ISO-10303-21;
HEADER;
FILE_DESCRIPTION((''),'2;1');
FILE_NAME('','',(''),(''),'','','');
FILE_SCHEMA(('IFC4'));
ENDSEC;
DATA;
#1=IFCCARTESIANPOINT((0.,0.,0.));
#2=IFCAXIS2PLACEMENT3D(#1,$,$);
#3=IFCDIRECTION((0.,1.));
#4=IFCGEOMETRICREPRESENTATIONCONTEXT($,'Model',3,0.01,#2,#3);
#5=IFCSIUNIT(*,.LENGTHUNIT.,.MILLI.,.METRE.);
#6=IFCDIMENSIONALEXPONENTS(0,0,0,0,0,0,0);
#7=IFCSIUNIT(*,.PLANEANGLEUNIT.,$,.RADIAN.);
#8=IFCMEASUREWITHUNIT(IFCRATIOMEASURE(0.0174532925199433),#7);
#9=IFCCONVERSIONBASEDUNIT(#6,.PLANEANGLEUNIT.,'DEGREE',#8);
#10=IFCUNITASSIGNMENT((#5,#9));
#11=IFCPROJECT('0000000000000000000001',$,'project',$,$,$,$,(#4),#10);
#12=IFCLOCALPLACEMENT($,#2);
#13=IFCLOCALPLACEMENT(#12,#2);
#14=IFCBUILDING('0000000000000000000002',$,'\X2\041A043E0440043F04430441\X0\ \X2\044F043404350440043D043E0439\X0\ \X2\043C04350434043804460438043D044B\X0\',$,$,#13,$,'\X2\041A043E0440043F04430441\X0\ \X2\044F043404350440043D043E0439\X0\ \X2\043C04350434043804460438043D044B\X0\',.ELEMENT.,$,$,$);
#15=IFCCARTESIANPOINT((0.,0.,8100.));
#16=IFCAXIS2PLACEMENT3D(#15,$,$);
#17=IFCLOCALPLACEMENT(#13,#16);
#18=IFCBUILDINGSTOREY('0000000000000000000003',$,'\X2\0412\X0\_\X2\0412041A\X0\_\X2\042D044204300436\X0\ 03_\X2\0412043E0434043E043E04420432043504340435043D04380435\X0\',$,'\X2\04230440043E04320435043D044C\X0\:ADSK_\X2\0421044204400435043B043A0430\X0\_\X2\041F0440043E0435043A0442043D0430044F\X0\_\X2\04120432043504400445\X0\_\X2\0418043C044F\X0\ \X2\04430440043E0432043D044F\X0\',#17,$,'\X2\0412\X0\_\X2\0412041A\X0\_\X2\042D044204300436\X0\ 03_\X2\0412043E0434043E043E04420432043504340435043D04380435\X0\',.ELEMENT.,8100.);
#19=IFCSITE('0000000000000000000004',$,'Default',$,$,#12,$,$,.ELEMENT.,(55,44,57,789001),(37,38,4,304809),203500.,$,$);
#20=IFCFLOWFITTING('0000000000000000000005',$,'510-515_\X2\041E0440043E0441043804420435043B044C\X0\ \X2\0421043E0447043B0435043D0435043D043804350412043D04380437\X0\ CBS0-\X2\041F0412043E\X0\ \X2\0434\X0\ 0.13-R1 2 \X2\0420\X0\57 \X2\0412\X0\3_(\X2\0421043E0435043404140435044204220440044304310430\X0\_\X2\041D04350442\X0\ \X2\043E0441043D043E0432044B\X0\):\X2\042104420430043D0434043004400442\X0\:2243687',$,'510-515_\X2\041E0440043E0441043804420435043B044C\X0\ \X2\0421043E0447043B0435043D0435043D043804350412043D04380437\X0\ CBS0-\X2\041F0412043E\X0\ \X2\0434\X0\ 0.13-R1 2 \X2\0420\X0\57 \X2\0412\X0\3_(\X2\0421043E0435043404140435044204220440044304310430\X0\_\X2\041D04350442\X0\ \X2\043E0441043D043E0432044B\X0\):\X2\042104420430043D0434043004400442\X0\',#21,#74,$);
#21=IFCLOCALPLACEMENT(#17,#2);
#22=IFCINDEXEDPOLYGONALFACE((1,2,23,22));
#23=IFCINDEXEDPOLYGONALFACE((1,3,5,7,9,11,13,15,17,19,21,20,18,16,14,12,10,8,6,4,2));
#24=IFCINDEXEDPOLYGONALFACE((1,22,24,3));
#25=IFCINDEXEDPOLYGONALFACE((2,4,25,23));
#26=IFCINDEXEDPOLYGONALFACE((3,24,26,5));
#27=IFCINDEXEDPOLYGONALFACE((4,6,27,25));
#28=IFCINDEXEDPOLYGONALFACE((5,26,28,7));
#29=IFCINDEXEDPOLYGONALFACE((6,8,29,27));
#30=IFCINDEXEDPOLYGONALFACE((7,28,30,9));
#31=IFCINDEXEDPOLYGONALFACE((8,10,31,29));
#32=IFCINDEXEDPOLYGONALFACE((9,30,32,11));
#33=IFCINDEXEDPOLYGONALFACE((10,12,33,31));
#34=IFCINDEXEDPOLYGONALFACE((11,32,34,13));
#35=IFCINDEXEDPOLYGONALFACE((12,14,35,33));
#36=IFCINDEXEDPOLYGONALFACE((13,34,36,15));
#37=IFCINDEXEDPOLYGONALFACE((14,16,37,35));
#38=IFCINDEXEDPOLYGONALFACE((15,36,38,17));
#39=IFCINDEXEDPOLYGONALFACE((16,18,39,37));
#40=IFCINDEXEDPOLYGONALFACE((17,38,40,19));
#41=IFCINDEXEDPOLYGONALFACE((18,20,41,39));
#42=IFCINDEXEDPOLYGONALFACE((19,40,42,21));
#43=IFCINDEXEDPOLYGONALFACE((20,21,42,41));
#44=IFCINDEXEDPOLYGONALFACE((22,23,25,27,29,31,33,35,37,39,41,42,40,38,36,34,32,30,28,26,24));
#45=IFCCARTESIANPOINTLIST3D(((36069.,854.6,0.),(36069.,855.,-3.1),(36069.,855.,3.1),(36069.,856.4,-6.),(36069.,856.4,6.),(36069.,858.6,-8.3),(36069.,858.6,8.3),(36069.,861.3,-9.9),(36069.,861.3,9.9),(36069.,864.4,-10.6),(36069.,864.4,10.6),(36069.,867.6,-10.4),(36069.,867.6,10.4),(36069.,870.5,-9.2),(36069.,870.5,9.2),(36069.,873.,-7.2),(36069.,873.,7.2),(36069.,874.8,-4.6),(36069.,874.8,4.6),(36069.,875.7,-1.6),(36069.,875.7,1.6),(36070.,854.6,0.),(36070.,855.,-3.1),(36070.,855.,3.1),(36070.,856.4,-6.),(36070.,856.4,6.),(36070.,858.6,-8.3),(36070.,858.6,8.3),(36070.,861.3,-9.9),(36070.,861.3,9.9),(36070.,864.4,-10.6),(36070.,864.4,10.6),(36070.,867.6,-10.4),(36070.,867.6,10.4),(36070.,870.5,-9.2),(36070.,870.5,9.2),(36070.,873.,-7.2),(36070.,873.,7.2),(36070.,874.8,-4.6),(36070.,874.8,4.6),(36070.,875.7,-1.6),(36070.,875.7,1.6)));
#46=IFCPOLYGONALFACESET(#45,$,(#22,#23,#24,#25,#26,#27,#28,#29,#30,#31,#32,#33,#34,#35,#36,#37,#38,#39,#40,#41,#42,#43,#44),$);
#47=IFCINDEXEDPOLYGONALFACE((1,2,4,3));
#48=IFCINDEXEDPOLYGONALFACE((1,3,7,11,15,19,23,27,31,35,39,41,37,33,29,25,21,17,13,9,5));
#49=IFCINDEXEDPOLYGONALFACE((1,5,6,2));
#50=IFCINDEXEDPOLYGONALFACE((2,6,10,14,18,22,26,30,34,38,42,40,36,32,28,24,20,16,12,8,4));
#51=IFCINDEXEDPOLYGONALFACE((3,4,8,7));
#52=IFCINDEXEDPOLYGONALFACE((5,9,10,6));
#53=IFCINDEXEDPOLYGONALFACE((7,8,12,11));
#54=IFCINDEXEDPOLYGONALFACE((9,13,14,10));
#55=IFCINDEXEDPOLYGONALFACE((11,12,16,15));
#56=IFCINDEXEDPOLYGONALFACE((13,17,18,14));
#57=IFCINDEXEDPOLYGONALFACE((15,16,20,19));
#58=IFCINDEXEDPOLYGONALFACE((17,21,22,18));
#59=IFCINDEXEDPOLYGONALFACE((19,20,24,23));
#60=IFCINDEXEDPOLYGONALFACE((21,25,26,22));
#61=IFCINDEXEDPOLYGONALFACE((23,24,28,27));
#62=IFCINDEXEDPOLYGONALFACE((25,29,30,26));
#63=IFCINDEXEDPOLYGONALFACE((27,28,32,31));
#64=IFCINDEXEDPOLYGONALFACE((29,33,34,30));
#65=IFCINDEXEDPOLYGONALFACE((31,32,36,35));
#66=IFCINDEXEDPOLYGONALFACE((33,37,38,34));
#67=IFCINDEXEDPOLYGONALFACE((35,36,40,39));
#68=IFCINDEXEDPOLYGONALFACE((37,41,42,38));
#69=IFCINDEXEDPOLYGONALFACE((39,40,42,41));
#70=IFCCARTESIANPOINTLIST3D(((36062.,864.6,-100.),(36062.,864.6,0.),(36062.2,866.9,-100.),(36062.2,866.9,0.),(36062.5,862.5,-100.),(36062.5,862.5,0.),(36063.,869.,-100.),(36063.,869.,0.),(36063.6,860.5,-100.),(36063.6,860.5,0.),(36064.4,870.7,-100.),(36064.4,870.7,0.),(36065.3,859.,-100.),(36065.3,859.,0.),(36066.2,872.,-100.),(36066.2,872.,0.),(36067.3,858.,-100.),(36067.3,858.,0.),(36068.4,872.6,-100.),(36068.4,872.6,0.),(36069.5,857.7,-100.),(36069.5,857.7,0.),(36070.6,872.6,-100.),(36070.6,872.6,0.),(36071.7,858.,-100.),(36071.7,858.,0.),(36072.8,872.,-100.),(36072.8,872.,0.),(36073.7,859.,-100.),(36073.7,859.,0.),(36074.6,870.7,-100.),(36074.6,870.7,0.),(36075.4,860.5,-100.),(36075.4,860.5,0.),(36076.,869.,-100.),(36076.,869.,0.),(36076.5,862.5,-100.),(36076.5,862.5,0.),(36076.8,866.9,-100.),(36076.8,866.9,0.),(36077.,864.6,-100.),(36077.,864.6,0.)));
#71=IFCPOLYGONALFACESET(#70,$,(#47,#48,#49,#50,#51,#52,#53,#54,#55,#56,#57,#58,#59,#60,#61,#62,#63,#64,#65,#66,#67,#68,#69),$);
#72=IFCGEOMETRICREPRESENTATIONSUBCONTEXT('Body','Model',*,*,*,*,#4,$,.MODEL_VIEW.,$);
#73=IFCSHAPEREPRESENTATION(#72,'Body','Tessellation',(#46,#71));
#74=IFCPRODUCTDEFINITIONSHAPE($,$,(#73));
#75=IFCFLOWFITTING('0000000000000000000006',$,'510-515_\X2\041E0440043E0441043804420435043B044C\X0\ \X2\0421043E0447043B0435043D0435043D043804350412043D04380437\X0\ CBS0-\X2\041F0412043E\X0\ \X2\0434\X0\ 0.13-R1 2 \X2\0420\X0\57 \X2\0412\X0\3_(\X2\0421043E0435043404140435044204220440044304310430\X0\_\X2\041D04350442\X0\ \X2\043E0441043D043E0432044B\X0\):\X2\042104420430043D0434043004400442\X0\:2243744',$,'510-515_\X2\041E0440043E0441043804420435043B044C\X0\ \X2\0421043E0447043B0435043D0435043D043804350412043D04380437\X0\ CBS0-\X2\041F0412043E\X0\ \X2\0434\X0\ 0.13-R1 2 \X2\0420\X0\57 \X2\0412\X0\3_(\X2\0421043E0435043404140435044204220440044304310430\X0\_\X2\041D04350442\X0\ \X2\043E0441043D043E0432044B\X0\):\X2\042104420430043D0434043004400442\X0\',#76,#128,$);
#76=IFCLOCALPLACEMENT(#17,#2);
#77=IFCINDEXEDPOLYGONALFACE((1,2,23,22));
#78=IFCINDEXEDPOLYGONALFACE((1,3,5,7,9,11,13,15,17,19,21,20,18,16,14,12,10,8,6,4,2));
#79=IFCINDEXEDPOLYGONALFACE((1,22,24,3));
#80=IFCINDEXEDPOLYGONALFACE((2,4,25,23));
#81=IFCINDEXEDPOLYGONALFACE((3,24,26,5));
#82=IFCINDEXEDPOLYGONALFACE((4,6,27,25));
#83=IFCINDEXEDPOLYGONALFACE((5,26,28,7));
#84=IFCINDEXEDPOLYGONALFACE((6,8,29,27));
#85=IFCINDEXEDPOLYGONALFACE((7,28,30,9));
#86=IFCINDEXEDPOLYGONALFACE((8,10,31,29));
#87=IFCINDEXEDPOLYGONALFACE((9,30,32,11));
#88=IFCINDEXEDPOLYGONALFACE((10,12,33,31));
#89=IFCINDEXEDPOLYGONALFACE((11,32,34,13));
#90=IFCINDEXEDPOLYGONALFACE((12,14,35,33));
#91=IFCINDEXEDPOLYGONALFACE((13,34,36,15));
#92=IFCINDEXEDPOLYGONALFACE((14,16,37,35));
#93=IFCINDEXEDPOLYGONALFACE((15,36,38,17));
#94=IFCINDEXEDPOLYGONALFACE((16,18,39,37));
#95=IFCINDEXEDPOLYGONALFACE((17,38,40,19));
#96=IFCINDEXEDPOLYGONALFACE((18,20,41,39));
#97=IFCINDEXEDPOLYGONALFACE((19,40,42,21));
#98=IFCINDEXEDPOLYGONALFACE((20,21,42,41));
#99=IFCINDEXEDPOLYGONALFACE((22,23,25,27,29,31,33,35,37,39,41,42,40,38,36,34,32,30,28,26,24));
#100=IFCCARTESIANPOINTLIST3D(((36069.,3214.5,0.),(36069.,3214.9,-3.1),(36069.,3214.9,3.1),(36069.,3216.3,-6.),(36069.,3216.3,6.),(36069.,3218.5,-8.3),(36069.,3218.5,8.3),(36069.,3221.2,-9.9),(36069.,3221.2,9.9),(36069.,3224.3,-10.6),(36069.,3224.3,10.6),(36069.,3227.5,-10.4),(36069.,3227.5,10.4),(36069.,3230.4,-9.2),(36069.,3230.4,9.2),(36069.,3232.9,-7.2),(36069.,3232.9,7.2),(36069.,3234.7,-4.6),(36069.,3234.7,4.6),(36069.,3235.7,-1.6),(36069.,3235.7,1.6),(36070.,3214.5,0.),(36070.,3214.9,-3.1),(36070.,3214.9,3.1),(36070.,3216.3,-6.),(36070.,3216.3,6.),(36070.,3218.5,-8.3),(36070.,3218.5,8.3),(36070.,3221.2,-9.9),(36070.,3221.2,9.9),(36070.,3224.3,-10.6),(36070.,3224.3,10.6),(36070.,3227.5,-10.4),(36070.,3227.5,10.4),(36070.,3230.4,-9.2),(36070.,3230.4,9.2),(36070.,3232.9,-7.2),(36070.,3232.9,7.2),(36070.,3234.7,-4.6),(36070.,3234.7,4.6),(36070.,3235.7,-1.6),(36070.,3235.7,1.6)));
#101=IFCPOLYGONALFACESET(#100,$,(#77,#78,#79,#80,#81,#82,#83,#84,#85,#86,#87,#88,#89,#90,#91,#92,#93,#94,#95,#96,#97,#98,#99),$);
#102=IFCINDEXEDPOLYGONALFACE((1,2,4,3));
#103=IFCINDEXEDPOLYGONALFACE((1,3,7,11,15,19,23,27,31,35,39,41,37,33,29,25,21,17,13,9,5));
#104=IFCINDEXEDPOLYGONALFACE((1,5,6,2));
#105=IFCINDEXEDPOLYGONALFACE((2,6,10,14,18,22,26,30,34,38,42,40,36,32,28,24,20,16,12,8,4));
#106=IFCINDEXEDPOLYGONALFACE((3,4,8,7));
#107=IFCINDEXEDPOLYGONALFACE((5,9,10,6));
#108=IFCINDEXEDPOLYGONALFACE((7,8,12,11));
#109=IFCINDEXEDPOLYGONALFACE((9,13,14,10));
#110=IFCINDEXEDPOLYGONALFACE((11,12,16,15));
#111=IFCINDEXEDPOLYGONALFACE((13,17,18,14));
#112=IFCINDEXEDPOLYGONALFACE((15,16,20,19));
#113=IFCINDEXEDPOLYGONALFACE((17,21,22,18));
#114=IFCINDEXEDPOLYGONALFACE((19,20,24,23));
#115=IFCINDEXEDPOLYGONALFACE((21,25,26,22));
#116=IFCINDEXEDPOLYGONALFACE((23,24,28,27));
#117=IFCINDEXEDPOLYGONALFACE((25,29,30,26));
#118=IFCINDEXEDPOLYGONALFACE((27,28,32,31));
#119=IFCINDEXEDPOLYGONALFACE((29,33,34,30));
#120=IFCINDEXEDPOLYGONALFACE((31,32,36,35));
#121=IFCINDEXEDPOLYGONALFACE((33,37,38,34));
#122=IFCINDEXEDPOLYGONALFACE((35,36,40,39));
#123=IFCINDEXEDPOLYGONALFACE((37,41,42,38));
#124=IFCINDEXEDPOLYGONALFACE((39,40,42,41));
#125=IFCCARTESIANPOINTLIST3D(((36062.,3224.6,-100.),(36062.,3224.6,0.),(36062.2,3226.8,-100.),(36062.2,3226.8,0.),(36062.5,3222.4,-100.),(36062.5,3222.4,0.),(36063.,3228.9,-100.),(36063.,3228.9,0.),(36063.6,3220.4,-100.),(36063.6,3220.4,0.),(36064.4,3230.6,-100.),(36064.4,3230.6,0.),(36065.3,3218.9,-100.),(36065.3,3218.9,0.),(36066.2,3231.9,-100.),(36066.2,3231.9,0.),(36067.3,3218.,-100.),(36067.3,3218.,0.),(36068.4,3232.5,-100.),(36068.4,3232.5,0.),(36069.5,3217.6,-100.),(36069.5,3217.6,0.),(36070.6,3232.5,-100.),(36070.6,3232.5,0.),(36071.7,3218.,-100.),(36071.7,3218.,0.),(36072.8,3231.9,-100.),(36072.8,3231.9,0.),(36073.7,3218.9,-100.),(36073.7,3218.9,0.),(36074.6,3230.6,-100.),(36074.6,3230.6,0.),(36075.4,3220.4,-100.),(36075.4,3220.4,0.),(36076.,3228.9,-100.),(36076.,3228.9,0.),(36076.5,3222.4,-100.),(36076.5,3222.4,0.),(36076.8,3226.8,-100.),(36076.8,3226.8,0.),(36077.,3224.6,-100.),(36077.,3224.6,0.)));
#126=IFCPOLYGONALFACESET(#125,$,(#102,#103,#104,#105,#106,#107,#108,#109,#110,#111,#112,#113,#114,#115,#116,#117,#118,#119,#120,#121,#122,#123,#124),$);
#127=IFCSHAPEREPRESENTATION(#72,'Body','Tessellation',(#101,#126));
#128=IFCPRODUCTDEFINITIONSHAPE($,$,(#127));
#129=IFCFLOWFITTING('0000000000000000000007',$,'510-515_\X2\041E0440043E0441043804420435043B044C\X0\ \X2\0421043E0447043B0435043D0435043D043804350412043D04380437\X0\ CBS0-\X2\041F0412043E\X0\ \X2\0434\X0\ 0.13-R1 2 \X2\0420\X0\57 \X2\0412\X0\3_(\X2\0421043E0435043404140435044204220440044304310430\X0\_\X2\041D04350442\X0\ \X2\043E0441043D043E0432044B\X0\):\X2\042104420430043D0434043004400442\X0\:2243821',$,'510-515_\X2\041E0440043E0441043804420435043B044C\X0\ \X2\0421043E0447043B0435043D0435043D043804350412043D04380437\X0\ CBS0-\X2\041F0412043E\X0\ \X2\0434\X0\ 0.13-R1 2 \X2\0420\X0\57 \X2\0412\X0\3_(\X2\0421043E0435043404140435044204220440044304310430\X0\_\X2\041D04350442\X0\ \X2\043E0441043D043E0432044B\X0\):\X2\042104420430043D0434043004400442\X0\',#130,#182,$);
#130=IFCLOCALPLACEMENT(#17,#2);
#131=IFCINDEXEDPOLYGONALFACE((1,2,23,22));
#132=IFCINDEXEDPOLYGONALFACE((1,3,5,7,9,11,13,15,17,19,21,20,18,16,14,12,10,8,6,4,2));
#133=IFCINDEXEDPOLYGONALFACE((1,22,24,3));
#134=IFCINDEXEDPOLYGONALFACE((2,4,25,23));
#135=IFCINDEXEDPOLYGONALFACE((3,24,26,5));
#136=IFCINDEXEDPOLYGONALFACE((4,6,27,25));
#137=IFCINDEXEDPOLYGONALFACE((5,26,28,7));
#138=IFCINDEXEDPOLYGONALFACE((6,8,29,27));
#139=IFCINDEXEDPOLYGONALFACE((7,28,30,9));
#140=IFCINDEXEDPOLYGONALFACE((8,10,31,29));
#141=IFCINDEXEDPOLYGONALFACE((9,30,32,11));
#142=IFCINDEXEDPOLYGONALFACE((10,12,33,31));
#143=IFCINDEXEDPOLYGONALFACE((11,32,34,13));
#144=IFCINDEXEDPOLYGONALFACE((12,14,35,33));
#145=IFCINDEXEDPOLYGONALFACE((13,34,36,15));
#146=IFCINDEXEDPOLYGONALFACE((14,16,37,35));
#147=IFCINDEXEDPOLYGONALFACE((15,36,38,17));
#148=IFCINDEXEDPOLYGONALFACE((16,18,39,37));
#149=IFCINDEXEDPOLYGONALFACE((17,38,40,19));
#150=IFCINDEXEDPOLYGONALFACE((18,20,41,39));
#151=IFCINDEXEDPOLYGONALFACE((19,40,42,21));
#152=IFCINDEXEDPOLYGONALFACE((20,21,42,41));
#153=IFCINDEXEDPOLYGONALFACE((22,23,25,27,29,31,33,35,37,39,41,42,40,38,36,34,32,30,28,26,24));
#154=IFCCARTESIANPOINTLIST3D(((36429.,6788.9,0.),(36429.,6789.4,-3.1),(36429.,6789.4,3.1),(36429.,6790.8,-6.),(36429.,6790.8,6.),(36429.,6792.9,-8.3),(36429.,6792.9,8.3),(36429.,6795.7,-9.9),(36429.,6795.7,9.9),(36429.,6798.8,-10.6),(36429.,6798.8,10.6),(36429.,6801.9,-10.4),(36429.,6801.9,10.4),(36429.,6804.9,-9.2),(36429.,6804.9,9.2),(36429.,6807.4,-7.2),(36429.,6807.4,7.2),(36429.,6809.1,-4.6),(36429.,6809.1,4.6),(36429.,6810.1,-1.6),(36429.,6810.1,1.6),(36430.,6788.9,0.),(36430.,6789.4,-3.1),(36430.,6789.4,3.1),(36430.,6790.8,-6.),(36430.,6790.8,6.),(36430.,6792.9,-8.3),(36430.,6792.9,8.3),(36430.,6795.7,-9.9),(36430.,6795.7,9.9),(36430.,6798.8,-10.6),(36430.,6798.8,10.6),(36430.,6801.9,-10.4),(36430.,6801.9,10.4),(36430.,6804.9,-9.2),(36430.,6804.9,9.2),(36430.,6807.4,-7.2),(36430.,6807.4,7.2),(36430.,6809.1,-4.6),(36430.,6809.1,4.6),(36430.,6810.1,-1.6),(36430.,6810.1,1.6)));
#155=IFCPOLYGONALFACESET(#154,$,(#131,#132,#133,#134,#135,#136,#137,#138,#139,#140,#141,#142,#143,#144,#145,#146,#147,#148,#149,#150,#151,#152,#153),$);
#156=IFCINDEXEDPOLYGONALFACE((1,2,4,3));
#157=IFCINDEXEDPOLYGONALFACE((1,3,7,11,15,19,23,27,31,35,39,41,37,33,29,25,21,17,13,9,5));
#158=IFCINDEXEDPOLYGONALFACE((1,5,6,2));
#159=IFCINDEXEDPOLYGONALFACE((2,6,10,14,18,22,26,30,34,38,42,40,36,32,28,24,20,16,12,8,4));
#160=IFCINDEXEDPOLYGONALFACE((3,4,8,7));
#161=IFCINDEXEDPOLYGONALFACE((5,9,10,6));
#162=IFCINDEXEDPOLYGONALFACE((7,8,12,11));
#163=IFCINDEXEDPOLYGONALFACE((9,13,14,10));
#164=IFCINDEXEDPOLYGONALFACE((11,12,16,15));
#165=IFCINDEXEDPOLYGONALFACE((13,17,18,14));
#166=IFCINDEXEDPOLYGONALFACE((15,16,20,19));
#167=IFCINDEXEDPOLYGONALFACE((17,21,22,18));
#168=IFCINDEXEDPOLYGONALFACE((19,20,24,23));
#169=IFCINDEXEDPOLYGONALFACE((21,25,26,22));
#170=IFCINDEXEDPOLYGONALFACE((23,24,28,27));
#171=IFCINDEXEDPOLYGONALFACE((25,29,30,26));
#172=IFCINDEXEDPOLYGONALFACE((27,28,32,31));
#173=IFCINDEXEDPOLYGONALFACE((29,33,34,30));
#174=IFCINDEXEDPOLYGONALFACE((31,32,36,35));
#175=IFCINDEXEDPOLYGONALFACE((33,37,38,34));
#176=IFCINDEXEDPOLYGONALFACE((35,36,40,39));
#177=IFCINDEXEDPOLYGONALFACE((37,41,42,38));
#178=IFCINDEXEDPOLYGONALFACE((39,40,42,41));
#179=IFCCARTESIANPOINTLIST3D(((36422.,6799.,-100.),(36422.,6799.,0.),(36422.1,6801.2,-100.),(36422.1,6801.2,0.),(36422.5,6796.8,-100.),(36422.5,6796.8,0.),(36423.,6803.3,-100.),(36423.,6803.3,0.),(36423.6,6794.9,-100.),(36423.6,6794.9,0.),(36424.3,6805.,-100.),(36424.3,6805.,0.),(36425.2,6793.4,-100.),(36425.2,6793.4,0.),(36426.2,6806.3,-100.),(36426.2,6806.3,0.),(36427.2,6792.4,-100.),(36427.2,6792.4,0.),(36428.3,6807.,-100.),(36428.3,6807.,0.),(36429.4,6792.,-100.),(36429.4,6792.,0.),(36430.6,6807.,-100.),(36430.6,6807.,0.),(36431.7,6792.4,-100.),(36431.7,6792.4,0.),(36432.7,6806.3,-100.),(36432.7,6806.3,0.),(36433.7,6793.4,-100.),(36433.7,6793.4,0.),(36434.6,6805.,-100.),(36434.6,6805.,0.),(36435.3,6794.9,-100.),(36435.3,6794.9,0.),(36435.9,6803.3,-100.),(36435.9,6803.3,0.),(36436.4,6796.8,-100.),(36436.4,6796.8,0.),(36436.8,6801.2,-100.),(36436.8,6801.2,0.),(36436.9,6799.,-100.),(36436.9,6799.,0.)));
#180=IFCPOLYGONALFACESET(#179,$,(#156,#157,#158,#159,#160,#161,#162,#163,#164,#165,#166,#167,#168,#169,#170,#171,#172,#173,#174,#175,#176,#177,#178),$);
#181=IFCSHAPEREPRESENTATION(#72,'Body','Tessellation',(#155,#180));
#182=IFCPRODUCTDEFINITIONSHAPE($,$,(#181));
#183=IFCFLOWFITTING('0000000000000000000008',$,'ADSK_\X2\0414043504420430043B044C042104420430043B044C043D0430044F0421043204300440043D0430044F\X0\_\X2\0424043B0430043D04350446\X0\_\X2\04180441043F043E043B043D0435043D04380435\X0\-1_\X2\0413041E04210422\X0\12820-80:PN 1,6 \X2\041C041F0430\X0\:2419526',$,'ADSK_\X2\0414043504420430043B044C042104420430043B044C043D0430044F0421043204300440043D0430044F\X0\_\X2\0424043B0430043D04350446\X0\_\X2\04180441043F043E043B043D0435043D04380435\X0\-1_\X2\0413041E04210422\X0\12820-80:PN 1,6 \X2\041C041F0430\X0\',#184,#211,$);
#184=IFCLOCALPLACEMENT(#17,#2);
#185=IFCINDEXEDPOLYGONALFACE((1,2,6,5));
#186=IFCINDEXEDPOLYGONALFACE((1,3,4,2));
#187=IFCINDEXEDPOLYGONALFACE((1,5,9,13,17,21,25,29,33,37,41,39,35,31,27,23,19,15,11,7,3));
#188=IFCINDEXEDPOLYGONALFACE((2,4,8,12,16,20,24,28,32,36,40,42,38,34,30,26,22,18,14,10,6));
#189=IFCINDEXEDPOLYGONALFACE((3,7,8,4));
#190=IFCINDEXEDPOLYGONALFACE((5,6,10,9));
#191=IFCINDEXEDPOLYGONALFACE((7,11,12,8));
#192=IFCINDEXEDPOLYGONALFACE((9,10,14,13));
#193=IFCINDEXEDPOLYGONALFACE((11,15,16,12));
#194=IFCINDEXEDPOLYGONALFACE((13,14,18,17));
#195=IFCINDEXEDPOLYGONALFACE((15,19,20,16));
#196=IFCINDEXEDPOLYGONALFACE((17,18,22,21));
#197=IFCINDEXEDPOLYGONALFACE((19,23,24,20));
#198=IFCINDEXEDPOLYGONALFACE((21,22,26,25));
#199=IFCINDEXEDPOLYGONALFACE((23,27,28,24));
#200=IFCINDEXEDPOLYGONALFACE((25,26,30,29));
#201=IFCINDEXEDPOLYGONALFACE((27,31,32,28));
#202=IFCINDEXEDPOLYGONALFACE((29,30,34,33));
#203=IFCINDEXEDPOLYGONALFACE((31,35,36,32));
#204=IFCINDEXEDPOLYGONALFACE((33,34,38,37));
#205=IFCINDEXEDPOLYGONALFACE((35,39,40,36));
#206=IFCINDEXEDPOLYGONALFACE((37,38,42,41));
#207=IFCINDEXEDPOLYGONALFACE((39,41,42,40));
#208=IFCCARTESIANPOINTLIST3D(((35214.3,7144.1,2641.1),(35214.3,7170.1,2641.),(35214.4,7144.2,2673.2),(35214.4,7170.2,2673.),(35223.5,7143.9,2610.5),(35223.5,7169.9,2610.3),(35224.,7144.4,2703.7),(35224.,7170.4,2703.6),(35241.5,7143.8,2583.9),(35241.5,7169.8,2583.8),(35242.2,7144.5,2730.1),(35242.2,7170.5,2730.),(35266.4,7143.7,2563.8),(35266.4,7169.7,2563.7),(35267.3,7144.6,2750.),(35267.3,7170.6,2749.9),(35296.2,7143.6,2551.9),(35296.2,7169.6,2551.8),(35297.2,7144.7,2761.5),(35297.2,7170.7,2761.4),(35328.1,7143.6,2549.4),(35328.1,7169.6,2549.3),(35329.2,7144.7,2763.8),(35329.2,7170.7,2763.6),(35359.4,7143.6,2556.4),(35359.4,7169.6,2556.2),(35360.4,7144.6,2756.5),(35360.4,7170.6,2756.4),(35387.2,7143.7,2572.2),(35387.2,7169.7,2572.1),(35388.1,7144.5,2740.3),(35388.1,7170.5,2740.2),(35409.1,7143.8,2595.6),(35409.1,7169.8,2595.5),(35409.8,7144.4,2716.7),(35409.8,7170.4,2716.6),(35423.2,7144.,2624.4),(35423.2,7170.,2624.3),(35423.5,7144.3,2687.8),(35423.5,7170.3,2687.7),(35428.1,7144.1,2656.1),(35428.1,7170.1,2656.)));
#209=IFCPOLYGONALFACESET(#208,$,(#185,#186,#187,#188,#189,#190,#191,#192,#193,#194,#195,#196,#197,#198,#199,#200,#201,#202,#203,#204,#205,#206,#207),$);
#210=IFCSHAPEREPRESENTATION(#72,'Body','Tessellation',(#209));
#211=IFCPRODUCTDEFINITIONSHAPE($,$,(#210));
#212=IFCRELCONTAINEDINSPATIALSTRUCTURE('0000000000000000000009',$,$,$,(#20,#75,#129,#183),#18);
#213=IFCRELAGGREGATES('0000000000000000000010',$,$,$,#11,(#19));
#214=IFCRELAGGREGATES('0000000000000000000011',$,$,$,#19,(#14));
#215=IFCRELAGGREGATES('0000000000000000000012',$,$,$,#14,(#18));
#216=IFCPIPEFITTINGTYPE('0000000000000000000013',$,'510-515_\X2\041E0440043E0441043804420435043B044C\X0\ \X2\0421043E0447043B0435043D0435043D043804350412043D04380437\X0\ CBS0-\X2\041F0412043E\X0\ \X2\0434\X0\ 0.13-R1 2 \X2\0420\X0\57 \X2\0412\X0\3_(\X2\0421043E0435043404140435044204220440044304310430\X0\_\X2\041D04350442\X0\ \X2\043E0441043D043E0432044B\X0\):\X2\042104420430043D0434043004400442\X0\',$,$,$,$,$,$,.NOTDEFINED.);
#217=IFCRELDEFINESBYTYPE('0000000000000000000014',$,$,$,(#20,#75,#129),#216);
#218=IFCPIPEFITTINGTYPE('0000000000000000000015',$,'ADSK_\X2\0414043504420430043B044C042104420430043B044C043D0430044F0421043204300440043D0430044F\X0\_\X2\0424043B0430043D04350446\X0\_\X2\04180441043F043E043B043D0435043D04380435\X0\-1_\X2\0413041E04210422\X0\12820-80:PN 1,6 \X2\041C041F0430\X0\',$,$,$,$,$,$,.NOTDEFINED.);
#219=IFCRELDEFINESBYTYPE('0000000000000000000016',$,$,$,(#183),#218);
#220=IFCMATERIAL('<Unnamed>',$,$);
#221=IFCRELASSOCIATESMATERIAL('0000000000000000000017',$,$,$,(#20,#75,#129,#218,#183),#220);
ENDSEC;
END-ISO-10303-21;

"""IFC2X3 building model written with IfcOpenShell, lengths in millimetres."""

from ifc_helpers import new_model, entity, si_unit, converted_unit, direction, frame, origin, origin_2d_with_axis, place, context, subcontext, project, spatial, circle, extrude, source, transform, mapped, material, type_object, type_shapes, element, save


model = new_model("IFC2X3")

# Units and contexts
model_context = context("Model", 3, precision=0.01, world=origin(), true_north=direction((0.0, 1.0)))
body_context = subcontext(model_context, "Body", "Model", "MODEL_VIEW")
ifc_project = project(units=[si_unit("LENGTHUNIT", "METRE", prefix="MILLI"), converted_unit("PLANEANGLEUNIT", "DEGREE", entity("IfcRatioMeasure", 0.0174532925199433), si_unit("PLANEANGLEUNIT", "RADIAN"), dimensions=[0, 0, 0, 0, 0, 0, 0])], contexts=[model_context])

# Site, building, storey
site_placement = place(None, origin())
site = spatial("IfcSite", under=ifc_project, at=site_placement, Name="Default", CompositionType="ELEMENT", RefLatitude=(55, 44, 57, 789001), RefLongitude=(37, 38, 4, 304809), RefElevation=203500.0)
building_placement = place(site_placement, origin())
building = spatial("IfcBuilding", under=site, at=building_placement, Name="Корпус ядерной медицины", LongName="Корпус ядерной медицины", CompositionType="ELEMENT")
storey_placement = place(building_placement, frame((0.0, 0.0, 8100.0)))
storey = spatial("IfcBuildingStorey", under=building, at=storey_placement, Name="В_ВК_Этаж 03_Водоотведение", ObjectType="Уровень:ADSK_Стрелка_Проектная_Вверх_Имя уровня", LongName="В_ВК_Этаж 03_Водоотведение", CompositionType="ELEMENT", Elevation=8100.0)

# Flow fittings
ifc_material = material(Name="<Unnamed>")
pipe_fitting_type_1 = type_object("IfcPipeFittingType", Name="510-515_Ороситель СочленениеВниз CBS0-ПВо д 0.13-R1 2 Р57 В3_(СоедДетТруба_Нет основы):Стандарт", PredefinedType="NOTDEFINED")
shared_shape_1 = source(origin(), body_context, "Body", "SweptSolid", [
    extrude(circle(Radius=10.7, at=origin_2d_with_axis()), frame((-0.5, 0.0, 0.0), z_axis=(1.0, 0.0, 0.0), x_axis=(0.0, 1.0, 0.0)), (0.0, 0.0, 1.0), 1.0),
    extrude(circle(Radius=7.5, at=origin_2d_with_axis()), frame((0.0, 0.0, -100.0), z_axis=(0.0, 0.0, 1.0), x_axis=(0.0, 1.0, 0.0)), (0.0, 0.0, 1.0), 100.0),
])
type_shapes(pipe_fitting_type_1, [shared_shape_1])
for number, where, z_axis, x_axis, name in (
    (1, (36069.5, 865.2, 0.0), (0.0, 0.0, 1.0), (-1.0, 0.0, 0.0), "510-515_Ороситель СочленениеВниз CBS0-ПВо д 0.13-R1 2 Р57 В3_(СоедДетТруба_Нет основы):Стандарт:2243687"),
    (2, (36069.5, 3225.1, 0.0), (0.0, 0.0, 1.0), (-1.0, 0.0, 0.0), "510-515_Ороситель СочленениеВниз CBS0-ПВо д 0.13-R1 2 Р57 В3_(СоедДетТруба_Нет основы):Стандарт:2243744"),
    (3, (36429.4, 6799.6, 0.0), (0.0, 0.0, 1.0), (-1.0, 0.0, 0.0), "510-515_Ороситель СочленениеВниз CBS0-ПВо д 0.13-R1 2 Р57 В3_(СоедДетТруба_Нет основы):Стандарт:2243821"),
):
    element("IfcFlowFitting", number, at=place(storey_placement, frame(where, z_axis=z_axis, x_axis=x_axis)), inside=storey, type_object=pipe_fitting_type_1, material=ifc_material, Name=name, ObjectType="510-515_Ороситель СочленениеВниз CBS0-ПВо д 0.13-R1 2 Р57 В3_(СоедДетТруба_Нет основы):Стандарт", context=body_context, shape_type="MappedRepresentation", body=[
        mapped(shared_shape_1, transform((0.0, 0.0, 0.0), scale=1.0)),
    ])
pipe_fitting_type_2 = type_object("IfcPipeFittingType", Name="ADSK_ДетальСтальнаяСварная_Фланец_Исполнение-1_ГОСТ12820-80:PN 1,6 МПа", PredefinedType="NOTDEFINED", material=ifc_material)
shared_shape_2 = source(origin(), body_context, "Body", "SweptSolid", [
    extrude(circle(Radius=107.5, at=origin_2d_with_axis()), frame((0.0, 0.0, 0.0), z_axis=(1.0, 0.0, 0.0), x_axis=(0.0, 1.0, 0.0)), (0.0, 0.0, 1.0), 26.0),
])
type_shapes(pipe_fitting_type_2, [shared_shape_2])
for number, where, z_axis, x_axis, name in (
    (4, (35320.6, 7170.1, 2656.5), (0.005, 0.005, 0.999975), (0.0, -0.999988, 0.005), "ADSK_ДетальСтальнаяСварная_Фланец_Исполнение-1_ГОСТ12820-80:PN 1,6 МПа:2419526"),
):
    element("IfcFlowFitting", number, at=place(storey_placement, frame(where, z_axis=z_axis, x_axis=x_axis)), inside=storey, type_object=pipe_fitting_type_2, material=ifc_material, Name=name, ObjectType="ADSK_ДетальСтальнаяСварная_Фланец_Исполнение-1_ГОСТ12820-80:PN 1,6 МПа", context=body_context, shape_type="MappedRepresentation", body=[
        mapped(shared_shape_2, transform((0.0, 0.0, 0.0), scale=1.0)),
    ])

save(model, "model.ifc")
